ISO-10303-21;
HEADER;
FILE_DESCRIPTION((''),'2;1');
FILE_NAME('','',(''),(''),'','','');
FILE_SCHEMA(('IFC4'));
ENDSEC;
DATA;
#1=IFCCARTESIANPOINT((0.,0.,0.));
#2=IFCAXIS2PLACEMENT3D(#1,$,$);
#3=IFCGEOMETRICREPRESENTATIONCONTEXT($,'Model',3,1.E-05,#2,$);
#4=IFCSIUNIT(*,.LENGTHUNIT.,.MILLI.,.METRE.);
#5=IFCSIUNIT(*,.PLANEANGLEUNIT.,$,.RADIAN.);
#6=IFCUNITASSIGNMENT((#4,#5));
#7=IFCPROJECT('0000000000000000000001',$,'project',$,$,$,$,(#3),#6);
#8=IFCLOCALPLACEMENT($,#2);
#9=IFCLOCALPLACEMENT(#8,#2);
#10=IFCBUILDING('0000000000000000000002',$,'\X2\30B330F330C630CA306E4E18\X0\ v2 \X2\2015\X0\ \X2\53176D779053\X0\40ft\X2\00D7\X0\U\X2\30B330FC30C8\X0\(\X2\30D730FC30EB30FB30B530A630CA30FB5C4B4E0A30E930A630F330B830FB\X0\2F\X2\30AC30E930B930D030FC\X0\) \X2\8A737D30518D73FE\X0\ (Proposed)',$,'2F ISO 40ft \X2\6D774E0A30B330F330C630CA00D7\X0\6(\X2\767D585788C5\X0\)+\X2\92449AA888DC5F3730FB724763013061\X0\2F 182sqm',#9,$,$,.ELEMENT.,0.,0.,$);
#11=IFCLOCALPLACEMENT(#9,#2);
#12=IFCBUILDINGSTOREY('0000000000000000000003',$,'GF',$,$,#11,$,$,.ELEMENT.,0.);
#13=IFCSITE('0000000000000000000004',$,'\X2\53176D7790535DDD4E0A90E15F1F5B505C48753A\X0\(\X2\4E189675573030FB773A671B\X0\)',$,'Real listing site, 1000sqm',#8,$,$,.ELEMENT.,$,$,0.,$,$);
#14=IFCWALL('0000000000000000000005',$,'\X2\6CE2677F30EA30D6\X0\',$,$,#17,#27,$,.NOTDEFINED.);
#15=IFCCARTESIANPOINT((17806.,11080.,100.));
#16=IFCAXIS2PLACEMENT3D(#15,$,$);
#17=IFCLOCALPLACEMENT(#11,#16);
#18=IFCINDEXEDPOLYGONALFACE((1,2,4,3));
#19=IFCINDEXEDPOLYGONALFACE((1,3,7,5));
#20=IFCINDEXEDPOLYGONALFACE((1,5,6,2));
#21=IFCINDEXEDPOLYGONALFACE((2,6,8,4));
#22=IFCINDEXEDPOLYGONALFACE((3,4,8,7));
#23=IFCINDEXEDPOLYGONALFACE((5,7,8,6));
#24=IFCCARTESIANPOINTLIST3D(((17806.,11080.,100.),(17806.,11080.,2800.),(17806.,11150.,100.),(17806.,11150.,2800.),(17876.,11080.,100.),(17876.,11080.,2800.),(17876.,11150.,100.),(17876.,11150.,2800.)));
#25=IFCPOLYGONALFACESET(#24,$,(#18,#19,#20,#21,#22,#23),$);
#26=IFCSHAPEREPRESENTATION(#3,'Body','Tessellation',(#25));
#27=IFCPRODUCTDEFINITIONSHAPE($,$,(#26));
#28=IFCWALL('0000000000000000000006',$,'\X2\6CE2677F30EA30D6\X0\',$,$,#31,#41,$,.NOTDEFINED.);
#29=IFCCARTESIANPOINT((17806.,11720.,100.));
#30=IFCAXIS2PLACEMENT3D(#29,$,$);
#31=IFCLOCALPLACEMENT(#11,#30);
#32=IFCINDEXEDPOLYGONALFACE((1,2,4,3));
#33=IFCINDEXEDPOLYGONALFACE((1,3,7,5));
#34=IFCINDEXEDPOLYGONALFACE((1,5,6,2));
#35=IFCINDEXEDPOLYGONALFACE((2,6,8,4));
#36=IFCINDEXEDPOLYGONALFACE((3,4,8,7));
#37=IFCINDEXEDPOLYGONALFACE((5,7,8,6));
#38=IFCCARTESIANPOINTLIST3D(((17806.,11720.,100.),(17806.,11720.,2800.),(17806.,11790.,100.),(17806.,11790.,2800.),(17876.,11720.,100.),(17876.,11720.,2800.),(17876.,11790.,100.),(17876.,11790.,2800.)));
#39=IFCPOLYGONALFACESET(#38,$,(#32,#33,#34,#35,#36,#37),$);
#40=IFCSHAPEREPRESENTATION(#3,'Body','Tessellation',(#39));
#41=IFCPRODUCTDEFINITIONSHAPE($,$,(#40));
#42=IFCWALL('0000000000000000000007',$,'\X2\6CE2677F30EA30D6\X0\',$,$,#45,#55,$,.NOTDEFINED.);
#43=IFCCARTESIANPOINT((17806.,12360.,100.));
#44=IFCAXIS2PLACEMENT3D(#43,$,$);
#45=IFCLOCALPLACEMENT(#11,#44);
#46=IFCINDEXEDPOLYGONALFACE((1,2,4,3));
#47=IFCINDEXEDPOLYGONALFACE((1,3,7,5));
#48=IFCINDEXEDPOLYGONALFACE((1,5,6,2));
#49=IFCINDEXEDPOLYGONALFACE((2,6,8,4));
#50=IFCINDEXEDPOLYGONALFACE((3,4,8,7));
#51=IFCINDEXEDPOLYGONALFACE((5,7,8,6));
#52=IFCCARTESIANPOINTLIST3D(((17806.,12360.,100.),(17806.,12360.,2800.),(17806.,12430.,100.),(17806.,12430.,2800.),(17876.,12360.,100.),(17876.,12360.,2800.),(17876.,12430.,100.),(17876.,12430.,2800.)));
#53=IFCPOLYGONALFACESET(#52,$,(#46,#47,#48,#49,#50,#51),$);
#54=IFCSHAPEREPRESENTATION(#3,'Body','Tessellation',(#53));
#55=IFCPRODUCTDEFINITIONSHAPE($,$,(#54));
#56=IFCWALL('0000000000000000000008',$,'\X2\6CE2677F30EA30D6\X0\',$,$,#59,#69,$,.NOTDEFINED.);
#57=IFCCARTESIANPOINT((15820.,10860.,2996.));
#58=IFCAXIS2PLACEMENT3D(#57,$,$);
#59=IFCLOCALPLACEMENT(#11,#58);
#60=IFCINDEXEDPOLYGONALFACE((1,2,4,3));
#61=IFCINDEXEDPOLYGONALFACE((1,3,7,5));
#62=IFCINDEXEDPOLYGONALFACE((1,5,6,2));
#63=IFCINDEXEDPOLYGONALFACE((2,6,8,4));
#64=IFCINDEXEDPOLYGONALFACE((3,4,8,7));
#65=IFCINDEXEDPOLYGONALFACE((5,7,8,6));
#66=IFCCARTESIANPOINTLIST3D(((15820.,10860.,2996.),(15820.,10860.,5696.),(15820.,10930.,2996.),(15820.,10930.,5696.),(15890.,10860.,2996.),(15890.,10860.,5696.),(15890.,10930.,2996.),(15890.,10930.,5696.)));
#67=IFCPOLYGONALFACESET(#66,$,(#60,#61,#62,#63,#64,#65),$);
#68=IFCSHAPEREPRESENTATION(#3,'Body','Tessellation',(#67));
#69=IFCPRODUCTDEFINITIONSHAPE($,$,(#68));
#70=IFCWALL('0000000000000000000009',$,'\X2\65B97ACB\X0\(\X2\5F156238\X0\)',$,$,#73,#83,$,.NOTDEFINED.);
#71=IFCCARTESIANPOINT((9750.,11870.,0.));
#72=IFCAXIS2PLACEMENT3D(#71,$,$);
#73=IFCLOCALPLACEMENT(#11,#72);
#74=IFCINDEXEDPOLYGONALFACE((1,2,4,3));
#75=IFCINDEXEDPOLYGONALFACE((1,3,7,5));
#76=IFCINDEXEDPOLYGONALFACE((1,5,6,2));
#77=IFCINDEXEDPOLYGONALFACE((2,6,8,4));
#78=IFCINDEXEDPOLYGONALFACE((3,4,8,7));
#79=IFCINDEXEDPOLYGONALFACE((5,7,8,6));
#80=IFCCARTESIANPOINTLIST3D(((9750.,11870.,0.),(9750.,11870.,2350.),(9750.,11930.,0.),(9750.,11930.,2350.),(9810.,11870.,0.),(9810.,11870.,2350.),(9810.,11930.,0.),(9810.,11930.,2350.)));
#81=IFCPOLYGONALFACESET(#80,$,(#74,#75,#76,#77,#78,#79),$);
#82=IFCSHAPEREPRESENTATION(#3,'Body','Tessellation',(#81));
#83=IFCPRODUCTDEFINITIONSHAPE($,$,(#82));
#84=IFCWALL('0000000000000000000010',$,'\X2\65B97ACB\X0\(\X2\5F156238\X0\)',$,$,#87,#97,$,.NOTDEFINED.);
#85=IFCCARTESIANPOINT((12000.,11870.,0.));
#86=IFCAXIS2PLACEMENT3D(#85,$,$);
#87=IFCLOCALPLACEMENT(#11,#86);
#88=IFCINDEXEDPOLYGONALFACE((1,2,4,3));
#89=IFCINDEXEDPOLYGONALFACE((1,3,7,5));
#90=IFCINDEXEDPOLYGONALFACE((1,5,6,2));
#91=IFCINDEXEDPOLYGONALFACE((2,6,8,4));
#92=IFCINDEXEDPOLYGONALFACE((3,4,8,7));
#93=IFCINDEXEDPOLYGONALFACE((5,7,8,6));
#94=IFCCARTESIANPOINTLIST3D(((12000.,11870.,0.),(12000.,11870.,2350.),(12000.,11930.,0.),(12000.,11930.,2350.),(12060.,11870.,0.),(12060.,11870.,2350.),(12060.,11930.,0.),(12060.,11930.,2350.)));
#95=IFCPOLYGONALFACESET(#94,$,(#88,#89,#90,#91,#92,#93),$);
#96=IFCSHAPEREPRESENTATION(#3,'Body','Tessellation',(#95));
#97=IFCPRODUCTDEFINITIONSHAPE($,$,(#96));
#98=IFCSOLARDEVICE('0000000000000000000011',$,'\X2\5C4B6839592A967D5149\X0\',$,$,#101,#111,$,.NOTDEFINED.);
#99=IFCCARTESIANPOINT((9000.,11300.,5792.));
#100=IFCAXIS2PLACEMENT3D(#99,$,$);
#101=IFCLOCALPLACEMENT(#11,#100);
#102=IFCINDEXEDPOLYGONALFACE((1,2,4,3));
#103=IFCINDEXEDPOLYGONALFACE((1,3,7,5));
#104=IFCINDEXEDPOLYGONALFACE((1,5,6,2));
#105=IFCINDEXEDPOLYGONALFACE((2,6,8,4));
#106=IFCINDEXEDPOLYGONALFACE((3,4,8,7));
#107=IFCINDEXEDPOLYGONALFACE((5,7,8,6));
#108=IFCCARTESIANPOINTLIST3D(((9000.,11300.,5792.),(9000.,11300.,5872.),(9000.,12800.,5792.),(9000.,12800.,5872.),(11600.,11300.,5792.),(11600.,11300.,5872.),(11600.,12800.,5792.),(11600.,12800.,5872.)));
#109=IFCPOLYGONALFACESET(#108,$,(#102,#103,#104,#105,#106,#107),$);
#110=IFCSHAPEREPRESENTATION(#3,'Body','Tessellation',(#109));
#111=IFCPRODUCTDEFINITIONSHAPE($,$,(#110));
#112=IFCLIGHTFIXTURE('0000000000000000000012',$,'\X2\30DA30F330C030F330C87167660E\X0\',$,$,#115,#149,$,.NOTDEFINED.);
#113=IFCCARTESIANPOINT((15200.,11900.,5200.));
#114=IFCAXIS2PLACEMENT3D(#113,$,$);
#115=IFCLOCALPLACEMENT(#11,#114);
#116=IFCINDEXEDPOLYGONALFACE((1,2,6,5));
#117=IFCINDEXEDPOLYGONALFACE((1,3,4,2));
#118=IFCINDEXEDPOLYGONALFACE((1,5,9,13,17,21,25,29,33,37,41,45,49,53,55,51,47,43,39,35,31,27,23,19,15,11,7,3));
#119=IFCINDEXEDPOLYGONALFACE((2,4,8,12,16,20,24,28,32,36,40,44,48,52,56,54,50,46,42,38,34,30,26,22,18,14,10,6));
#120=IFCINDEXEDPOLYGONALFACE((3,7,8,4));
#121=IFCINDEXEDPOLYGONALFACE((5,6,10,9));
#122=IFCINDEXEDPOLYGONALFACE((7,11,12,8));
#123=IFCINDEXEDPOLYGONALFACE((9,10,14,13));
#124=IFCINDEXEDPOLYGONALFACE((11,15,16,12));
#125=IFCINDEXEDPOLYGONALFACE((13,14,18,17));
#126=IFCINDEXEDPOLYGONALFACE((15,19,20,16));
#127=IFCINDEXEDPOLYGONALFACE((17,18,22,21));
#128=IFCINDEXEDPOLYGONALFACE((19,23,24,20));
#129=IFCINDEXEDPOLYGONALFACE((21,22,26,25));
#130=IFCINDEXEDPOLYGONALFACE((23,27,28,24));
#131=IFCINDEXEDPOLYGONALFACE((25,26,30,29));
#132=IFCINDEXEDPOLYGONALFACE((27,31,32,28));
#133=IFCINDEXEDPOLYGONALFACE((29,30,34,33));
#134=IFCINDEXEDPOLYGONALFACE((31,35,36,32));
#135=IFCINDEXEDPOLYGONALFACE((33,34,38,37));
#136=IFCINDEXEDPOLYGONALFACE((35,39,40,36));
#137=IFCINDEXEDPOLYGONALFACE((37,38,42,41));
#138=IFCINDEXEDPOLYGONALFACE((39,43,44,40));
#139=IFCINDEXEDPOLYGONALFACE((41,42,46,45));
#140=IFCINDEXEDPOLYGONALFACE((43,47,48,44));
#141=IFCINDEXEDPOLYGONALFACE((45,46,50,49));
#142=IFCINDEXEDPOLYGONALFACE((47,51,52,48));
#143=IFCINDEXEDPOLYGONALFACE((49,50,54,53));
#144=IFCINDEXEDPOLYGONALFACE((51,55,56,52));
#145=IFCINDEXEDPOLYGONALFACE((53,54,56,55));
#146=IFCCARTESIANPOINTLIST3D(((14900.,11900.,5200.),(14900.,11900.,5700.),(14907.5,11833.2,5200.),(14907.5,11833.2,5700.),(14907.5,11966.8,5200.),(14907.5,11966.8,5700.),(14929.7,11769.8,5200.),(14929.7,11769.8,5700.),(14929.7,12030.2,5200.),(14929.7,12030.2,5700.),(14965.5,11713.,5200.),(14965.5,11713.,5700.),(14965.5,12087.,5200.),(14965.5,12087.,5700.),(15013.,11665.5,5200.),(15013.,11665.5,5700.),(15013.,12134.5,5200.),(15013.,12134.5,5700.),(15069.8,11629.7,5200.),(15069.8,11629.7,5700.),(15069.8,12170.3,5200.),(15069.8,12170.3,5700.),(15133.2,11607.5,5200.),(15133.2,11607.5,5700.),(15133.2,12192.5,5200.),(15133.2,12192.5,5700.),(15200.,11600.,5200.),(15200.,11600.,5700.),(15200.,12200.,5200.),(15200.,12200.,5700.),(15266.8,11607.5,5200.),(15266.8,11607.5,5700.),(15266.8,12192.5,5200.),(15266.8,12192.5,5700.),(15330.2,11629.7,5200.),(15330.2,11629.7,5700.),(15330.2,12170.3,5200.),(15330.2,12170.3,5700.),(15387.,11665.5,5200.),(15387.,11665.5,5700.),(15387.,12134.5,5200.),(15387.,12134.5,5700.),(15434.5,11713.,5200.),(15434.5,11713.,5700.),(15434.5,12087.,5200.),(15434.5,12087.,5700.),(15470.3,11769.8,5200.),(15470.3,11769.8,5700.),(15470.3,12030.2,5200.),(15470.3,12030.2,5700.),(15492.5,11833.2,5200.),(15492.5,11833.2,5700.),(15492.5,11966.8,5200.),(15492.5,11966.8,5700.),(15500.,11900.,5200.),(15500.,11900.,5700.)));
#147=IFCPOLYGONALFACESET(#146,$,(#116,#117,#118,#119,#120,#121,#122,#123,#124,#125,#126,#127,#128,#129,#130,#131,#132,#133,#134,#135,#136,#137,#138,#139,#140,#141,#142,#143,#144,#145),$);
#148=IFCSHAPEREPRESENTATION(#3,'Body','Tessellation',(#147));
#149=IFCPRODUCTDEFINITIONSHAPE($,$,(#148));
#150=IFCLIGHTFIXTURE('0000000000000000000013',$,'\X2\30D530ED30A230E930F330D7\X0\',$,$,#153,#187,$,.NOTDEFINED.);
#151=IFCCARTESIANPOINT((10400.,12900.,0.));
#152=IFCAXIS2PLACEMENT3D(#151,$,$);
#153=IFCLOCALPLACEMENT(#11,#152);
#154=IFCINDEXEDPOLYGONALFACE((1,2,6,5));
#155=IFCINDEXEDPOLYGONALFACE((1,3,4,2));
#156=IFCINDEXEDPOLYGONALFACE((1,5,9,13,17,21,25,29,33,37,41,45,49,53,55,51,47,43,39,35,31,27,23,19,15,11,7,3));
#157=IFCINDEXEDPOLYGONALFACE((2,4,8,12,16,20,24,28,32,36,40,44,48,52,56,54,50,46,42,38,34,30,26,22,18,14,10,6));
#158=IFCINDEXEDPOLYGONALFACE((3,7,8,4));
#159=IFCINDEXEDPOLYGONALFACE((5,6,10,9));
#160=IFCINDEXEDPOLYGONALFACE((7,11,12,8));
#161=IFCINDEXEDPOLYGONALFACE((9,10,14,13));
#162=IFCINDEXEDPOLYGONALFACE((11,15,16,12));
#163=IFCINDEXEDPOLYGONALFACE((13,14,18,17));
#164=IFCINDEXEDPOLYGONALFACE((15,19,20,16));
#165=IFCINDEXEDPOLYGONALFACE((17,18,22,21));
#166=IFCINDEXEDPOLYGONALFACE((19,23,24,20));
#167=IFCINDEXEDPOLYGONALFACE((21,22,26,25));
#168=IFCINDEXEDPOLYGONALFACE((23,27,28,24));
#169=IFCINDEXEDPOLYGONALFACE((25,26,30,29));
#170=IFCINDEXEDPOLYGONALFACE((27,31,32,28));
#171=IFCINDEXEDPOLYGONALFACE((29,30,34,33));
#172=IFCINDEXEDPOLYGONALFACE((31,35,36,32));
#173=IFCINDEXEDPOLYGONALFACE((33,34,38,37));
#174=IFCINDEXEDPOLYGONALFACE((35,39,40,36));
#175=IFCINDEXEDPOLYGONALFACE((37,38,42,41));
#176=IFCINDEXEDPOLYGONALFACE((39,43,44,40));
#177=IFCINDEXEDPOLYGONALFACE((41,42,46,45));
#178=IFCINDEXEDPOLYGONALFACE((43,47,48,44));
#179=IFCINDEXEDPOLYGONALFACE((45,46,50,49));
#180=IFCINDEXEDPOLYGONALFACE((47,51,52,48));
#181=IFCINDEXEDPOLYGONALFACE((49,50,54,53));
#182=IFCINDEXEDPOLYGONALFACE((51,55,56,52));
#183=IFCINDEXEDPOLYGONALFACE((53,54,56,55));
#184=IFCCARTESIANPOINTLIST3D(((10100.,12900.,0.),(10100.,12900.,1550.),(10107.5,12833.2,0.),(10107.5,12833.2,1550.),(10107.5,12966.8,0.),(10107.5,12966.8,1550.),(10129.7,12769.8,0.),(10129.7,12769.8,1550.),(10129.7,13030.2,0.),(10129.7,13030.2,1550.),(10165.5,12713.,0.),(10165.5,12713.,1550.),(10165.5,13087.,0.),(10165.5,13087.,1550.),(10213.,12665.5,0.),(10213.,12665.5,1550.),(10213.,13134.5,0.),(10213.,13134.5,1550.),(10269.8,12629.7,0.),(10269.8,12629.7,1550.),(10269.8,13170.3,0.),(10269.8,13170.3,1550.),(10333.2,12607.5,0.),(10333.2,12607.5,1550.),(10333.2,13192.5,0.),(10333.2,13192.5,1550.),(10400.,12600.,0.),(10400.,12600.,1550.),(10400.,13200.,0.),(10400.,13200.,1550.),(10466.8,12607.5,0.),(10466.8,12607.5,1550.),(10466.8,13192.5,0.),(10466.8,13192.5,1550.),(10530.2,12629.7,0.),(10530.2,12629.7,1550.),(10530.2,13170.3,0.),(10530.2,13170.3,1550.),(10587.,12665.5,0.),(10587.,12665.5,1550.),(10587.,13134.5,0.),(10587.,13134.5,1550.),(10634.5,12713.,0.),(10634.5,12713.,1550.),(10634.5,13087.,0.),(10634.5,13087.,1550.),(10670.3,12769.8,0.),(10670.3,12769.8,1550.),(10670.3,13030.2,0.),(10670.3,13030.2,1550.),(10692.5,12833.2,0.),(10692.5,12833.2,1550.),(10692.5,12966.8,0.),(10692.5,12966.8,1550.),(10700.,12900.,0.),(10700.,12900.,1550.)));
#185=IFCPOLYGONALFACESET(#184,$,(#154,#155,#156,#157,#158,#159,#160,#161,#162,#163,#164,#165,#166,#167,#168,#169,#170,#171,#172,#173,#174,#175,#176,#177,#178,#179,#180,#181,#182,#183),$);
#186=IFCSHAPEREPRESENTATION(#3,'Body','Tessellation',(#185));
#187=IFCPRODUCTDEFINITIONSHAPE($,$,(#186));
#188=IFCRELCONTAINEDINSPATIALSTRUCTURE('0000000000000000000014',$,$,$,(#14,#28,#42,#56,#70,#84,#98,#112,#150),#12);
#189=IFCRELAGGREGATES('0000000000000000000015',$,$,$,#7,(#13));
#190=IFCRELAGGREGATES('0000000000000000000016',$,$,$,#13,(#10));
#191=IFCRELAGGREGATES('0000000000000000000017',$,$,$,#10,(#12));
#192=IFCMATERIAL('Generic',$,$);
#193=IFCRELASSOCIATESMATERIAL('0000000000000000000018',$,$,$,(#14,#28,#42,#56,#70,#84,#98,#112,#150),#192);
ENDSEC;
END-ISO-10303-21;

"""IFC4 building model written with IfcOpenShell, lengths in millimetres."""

from ifc_helpers import new_model, si_unit, frame, frame_2d, origin, origin_2d, place, context, project, spatial, rectangle, circle, extrude, material, element, save


model = new_model("IFC4")

# Units and contexts
model_context = context("Model", 3, precision=1e-05, world=origin())
ifc_project = project(units=[si_unit("LENGTHUNIT", "METRE", prefix="MILLI"), si_unit("PLANEANGLEUNIT", "RADIAN")], contexts=[model_context])

# Site, building, storey
site_placement = place(None, origin())
site = spatial("IfcSite", under=ifc_project, at=site_placement, Name="北海道川上郡弟子屈町(丘陵地・眺望)", ObjectType="Real listing site, 1000sqm", CompositionType="ELEMENT", RefElevation=0.0)
building_placement = place(site_placement, origin())
building = spatial("IfcBuilding", under=site, at=building_placement, Name="コンテナの丘 v2 ― 北海道40ft×Uコート(プール・サウナ・屋上ラウンジ・2Fガラスバー) 詳細再現 (Proposed)", ObjectType="2F ISO 40ft 海上コンテナ×6(白塗装)+鉄骨補強・片持ち2F 182sqm", CompositionType="ELEMENT", ElevationOfRefHeight=0.0, ElevationOfTerrain=0.0)
storey_placement = place(building_placement, origin())
storey = spatial("IfcBuildingStorey", under=building, at=storey_placement, Name="GF", CompositionType="ELEMENT", Elevation=0.0)

# Walls
ifc_material = material(Name="Generic")
wall_1_placement = place(storey_placement, frame((17806.0, 11080.0, 100.0)))
element("IfcWall", 1, at=wall_1_placement, inside=storey, material=ifc_material, Name="波板リブ", PredefinedType="NOTDEFINED", context=model_context, shape_type="SweptSolid", body=[
    extrude(rectangle(XDim=70.0, YDim=70.0, at=frame_2d((35.0, 35.0))), frame((17806.0, 11080.0, 100.0)), (0.0, 0.0, 1.0), 2700.0),
])
wall_2_placement = place(storey_placement, frame((17806.0, 11720.0, 100.0)))
element("IfcWall", 2, at=wall_2_placement, inside=storey, material=ifc_material, Name="波板リブ", PredefinedType="NOTDEFINED", context=model_context, shape_type="SweptSolid", body=[
    extrude(rectangle(XDim=70.0, YDim=70.0, at=frame_2d((35.0, 35.0))), frame((17806.0, 11720.0, 100.0)), (0.0, 0.0, 1.0), 2700.0),
])
wall_3_placement = place(storey_placement, frame((17806.0, 12360.0, 100.0)))
element("IfcWall", 3, at=wall_3_placement, inside=storey, material=ifc_material, Name="波板リブ", PredefinedType="NOTDEFINED", context=model_context, shape_type="SweptSolid", body=[
    extrude(rectangle(XDim=70.0, YDim=70.0, at=frame_2d((35.0, 35.0))), frame((17806.0, 12360.0, 100.0)), (0.0, 0.0, 1.0), 2700.0),
])
wall_4_placement = place(storey_placement, frame((15820.0, 10860.0, 2996.0)))
element("IfcWall", 4, at=wall_4_placement, inside=storey, material=ifc_material, Name="波板リブ", PredefinedType="NOTDEFINED", context=model_context, shape_type="SweptSolid", body=[
    extrude(rectangle(XDim=70.0, YDim=70.0, at=frame_2d((35.0, 35.0))), frame((15820.0, 10860.0, 2996.0)), (0.0, 0.0, 1.0), 2700.0),
])
wall_5_placement = place(storey_placement, frame((9750.0, 11870.0, 0.0)))
element("IfcWall", 5, at=wall_5_placement, inside=storey, material=ifc_material, Name="方立(引戸)", PredefinedType="NOTDEFINED", context=model_context, shape_type="SweptSolid", body=[
    extrude(rectangle(XDim=60.0, YDim=60.0, at=frame_2d((30.0, 30.0))), frame((9750.0, 11870.0, 0.0)), (0.0, 0.0, 1.0), 2350.0),
])
wall_6_placement = place(storey_placement, frame((12000.0, 11870.0, 0.0)))
element("IfcWall", 6, at=wall_6_placement, inside=storey, material=ifc_material, Name="方立(引戸)", PredefinedType="NOTDEFINED", context=model_context, shape_type="SweptSolid", body=[
    extrude(rectangle(XDim=60.0, YDim=60.0, at=frame_2d((30.0, 30.0))), frame((12000.0, 11870.0, 0.0)), (0.0, 0.0, 1.0), 2350.0),
])

# Solar device
solar_device_1_placement = place(storey_placement, frame((9000.0, 11300.0, 5792.0)))
element("IfcSolarDevice", 7, at=solar_device_1_placement, inside=storey, material=ifc_material, Name="屋根太陽光", PredefinedType="NOTDEFINED", context=model_context, shape_type="SweptSolid", body=[
    extrude(rectangle(XDim=2600.0, YDim=1500.0, at=frame_2d((1300.0, 750.0))), frame((9000.0, 11300.0, 5792.0)), (0.0, 0.0, 1.0), 80.0),
])

# Light fixtures
light_fixture_1_placement = place(storey_placement, frame((15200.0, 11900.0, 5200.0)))
element("IfcLightFixture", 8, at=light_fixture_1_placement, inside=storey, material=ifc_material, Name="ペンダント照明", PredefinedType="NOTDEFINED", context=model_context, shape_type="SweptSolid", body=[
    extrude(circle(Radius=300.0, at=origin_2d()), frame((15200.0, 11900.0, 5200.0)), (0.0, 0.0, 1.0), 500.0),
])
light_fixture_2_placement = place(storey_placement, frame((10400.0, 12900.0, 0.0)))
element("IfcLightFixture", 9, at=light_fixture_2_placement, inside=storey, material=ifc_material, Name="フロアランプ", PredefinedType="NOTDEFINED", context=model_context, shape_type="SweptSolid", body=[
    extrude(circle(Radius=300.0, at=origin_2d()), frame((10400.0, 12900.0, 0.0)), (0.0, 0.0, 1.0), 1550.0),
])

save(model, "model.ifc")
